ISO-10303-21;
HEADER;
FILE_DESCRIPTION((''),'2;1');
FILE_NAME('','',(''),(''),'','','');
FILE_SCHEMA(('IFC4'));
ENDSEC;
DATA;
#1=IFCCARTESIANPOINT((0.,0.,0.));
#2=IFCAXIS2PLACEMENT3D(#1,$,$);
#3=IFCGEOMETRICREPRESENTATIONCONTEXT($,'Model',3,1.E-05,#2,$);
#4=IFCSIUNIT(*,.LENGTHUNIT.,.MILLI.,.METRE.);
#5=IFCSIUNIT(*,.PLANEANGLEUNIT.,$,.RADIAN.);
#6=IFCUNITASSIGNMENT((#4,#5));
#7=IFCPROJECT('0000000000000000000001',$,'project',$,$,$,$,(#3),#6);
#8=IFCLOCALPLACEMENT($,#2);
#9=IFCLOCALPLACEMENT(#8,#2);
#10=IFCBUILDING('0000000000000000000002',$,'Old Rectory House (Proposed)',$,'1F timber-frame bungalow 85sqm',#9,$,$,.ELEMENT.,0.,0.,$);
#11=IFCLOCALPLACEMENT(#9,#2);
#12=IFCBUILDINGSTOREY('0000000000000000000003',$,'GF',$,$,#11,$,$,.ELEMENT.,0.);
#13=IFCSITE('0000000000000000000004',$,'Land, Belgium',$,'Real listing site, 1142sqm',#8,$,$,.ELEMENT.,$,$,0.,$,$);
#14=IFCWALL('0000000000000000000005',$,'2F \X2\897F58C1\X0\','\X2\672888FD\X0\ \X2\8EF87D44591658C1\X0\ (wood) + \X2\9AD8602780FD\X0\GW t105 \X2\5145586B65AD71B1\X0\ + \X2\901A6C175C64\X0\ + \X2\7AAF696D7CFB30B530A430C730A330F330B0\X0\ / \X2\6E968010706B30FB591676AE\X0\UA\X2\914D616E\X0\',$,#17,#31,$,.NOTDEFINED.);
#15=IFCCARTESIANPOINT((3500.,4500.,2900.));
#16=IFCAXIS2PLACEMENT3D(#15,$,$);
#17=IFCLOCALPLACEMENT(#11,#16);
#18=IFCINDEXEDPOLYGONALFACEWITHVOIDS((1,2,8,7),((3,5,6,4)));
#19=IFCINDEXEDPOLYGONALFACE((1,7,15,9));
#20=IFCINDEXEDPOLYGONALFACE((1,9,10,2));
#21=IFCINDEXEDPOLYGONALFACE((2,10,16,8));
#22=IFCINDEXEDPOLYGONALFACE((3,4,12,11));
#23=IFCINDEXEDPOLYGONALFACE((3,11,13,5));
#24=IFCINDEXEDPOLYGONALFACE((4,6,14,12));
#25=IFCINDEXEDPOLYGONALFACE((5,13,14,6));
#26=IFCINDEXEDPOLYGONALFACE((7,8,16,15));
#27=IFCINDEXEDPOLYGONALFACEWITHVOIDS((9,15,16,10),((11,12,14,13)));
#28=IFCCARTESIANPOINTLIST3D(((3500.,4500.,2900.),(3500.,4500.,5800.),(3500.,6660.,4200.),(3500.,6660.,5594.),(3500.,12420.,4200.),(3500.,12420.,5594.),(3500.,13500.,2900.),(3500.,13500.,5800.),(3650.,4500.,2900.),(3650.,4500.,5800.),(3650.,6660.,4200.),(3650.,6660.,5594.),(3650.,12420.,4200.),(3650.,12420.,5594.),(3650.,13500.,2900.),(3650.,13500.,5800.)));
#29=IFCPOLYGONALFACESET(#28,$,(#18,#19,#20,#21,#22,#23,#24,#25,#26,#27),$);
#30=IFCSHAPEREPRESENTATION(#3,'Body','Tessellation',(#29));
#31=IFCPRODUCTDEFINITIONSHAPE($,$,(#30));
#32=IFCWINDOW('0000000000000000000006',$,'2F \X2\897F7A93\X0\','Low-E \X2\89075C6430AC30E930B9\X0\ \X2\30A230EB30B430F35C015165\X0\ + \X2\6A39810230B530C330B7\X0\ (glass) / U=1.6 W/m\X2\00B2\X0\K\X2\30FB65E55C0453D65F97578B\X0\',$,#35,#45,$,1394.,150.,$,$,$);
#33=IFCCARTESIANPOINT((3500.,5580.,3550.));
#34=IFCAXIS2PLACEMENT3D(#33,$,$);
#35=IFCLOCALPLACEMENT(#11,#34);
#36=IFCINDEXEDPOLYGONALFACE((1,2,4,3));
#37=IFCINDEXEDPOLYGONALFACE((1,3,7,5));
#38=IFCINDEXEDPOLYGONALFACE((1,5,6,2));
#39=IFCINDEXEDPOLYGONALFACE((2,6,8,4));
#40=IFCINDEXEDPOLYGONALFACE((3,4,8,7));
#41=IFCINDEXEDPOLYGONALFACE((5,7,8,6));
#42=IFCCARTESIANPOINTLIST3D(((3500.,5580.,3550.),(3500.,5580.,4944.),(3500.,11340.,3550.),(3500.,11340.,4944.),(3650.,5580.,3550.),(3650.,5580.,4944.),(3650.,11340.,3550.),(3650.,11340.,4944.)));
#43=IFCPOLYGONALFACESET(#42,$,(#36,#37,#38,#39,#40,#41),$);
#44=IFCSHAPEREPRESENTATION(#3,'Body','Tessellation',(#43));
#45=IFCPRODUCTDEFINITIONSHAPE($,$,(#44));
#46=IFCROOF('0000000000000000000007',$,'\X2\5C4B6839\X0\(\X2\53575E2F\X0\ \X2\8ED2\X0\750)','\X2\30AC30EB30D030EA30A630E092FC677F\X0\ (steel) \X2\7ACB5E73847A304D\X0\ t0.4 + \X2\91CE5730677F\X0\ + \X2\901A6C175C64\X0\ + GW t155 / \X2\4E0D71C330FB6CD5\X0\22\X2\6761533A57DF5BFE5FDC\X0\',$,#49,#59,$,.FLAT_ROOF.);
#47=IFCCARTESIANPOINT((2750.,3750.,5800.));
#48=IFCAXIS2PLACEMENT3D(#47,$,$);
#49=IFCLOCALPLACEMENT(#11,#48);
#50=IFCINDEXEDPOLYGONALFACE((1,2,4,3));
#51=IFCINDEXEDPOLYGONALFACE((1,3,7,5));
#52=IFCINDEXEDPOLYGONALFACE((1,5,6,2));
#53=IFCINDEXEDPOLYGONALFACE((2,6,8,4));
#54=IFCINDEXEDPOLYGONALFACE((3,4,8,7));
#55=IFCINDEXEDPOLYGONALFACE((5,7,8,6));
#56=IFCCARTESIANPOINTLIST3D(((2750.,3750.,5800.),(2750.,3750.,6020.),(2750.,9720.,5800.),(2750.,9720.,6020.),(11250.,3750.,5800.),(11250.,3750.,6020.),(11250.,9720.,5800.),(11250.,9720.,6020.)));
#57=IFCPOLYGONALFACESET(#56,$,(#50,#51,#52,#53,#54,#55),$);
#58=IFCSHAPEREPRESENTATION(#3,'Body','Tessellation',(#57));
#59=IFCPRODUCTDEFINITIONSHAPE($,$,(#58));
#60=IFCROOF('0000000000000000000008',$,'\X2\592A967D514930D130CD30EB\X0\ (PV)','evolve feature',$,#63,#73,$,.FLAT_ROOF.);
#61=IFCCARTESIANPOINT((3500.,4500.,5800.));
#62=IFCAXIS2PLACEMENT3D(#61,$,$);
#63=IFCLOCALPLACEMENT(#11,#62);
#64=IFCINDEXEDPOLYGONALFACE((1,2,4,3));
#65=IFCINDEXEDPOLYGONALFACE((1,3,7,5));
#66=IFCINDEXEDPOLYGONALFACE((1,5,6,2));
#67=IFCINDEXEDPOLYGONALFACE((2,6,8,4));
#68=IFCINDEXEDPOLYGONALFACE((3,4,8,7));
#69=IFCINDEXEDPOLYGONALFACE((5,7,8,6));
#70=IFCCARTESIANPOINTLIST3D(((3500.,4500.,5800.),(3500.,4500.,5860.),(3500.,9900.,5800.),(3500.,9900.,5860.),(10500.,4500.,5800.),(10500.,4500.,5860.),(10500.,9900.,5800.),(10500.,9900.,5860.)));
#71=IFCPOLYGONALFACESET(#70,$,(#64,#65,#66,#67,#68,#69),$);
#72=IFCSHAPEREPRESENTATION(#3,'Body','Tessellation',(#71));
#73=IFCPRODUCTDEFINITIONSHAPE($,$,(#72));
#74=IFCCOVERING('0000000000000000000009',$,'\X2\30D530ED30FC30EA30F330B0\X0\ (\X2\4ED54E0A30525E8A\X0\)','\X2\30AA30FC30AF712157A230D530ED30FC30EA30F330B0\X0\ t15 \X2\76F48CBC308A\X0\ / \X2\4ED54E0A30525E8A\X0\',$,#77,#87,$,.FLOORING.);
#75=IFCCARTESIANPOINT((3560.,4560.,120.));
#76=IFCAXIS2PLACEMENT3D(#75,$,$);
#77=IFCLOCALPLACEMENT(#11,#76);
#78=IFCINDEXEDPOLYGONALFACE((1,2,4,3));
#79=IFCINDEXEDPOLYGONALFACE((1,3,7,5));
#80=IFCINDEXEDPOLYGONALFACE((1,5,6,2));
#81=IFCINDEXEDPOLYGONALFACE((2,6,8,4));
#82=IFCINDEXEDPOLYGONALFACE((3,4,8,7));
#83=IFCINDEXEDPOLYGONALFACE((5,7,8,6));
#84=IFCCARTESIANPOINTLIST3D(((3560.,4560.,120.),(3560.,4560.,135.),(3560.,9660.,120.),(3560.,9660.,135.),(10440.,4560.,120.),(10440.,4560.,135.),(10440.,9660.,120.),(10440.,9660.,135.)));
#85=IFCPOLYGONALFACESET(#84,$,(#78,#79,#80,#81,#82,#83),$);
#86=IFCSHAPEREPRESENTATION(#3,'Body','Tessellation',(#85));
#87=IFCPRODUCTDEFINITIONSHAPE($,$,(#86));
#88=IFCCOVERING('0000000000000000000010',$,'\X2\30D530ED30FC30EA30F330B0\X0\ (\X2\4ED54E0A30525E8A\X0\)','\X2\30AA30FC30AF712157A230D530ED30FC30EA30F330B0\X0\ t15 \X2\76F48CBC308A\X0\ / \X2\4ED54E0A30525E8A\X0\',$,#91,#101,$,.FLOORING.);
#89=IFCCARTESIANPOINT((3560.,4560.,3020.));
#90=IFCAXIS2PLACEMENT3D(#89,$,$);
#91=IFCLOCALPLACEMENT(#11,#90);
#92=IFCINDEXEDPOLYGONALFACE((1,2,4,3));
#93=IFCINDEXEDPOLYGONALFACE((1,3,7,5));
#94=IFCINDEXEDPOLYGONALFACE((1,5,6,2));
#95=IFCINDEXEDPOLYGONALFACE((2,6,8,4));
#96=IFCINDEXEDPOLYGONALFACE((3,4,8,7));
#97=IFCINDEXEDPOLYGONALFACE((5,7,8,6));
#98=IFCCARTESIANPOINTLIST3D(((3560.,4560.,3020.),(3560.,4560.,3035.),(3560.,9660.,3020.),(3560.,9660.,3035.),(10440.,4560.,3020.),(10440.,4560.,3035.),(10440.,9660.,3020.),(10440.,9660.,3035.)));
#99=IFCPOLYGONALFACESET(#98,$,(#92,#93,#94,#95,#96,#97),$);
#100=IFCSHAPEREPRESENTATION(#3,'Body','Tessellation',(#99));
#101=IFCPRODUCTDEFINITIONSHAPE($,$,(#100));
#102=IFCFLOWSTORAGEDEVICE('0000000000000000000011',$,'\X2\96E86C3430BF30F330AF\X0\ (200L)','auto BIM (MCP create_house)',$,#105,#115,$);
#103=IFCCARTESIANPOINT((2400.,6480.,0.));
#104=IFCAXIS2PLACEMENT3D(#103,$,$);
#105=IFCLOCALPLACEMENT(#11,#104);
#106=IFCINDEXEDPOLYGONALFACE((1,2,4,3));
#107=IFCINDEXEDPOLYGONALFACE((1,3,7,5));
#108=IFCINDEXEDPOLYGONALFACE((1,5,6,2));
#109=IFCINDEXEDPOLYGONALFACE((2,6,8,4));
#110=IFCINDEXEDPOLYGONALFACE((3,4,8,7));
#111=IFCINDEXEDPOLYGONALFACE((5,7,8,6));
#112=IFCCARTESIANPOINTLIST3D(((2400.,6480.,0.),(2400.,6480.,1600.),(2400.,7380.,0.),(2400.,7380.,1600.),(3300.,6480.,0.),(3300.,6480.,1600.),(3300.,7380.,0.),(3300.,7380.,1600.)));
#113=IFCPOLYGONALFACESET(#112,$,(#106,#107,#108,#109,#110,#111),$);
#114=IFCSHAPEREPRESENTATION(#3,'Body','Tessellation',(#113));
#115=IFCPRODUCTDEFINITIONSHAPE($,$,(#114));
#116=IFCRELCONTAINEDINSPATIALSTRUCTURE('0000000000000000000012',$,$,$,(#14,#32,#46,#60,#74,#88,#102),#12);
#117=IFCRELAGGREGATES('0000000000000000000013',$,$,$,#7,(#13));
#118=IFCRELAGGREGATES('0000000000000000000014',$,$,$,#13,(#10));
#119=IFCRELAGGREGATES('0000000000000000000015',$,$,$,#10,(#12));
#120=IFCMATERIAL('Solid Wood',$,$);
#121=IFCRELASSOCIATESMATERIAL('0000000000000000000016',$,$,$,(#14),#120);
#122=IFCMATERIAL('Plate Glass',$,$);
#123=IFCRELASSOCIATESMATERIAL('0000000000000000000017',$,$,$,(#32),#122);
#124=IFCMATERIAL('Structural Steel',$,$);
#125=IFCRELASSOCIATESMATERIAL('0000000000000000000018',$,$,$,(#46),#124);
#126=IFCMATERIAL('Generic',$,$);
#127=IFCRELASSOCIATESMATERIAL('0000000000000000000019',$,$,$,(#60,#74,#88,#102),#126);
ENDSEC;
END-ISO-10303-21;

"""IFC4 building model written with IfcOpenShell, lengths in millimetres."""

from ifc_helpers import new_model, si_unit, frame, frame_2d, origin, place, context, project, spatial, rectangle, extrude, material, element, fill, save


model = new_model("IFC4")

# Units and contexts
model_context = context("Model", 3, precision=1e-05, world=origin())
ifc_project = project(units=[si_unit("LENGTHUNIT", "METRE", prefix="MILLI"), si_unit("PLANEANGLEUNIT", "RADIAN")], contexts=[model_context])

# Site, building, storey
site_placement = place(None, origin())
site = spatial("IfcSite", under=ifc_project, at=site_placement, Name="Land, Belgium", ObjectType="Real listing site, 1142sqm", CompositionType="ELEMENT", RefElevation=0.0)
building_placement = place(site_placement, origin())
building = spatial("IfcBuilding", under=site, at=building_placement, Name="Old Rectory House (Proposed)", ObjectType="1F timber-frame bungalow 85sqm", CompositionType="ELEMENT", ElevationOfRefHeight=0.0, ElevationOfTerrain=0.0)
storey_placement = place(building_placement, origin())
storey = spatial("IfcBuildingStorey", under=building, at=storey_placement, Name="GF", CompositionType="ELEMENT", Elevation=0.0)

# Shared definitions
ifc_material_1 = material(Name="Solid Wood")
ifc_material_2 = material(Name="Generic")

# Shared definitions
ifc_material_3 = material(Name="Plate Glass")

# Wall, opening, window
wall_1_placement = place(storey_placement, frame((3500.0, 4500.0, 2900.0)))
wall_1 = element("IfcWall", 1, at=wall_1_placement, inside=storey, material=ifc_material_1, Name="2F 西壁", Description="木製 軸組外壁 (wood) + 高性能GW t105 充填断熱 + 通気層 + 窯業系サイディング / 準耐火・外皮UA配慮", PredefinedType="NOTDEFINED", context=model_context, shape_type="SweptSolid", body=[
    extrude(rectangle(XDim=150.0, YDim=9000.0, at=frame_2d((75.0, 4500.0))), frame((3500.0, 4500.0, 2900.0)), (0.0, 0.0, 1.0), 2900.0),
])
opening_1_placement = place(storey_placement, frame((3500.0, 5580.0, 3550.0)))
opening_1 = element("IfcOpeningElement", 2, at=opening_1_placement, cuts=wall_1, PredefinedType="NOTDEFINED", context=model_context, shape_type="SweptSolid", body=[
    extrude(rectangle(XDim=150.0, YDim=5760.0, at=frame_2d((75.0, 2880.0))), frame((3500.0, 5580.0, 3550.0)), (0.0, 0.0, 1.0), 1394.0),
])
window_1_placement = place(storey_placement, frame((3500.0, 5580.0, 3550.0)))
window_1 = element("IfcWindow", 3, at=window_1_placement, inside=storey, material=ifc_material_3, Name="2F 西窓", Description="Low-E 複層ガラス アルゴン封入 + 樹脂サッシ (glass) / U=1.6 W/m²K・日射取得型", OverallHeight=1394.0, OverallWidth=150.0, context=model_context, shape_type="SweptSolid", body=[
    extrude(rectangle(XDim=150.0, YDim=5760.0, at=frame_2d((75.0, 2880.0))), frame((3500.0, 5580.0, 3550.0)), (0.0, 0.0, 1.0), 1394.0),
])
fill(opening_1, window_1)

# Roofs
ifc_material_4 = material(Name="Structural Steel")
for number, where, name in (
    (4, (2750.0, 3750.0, 5800.0), "屋根(南帯 軒750)"),
):
    element("IfcRoof", number, at=place(storey_placement, frame(where)), inside=storey, material=ifc_material_4, Name=name, Description="ガルバリウム鋼板 (steel) 立平葺き t0.4 + 野地板 + 通気層 + GW t155 / 不燃・法22条区域対応", PredefinedType="FLAT_ROOF", context=model_context, shape_type="SweptSolid", body=[
        extrude(rectangle(XDim=8500.0, YDim=5970.0, at=frame_2d((4250.0, 2985.0))), frame((2750.0, 3750.0, 5800.0)), (0.0, 0.0, 1.0), 220.0),
    ])
roof_placement = place(storey_placement, frame((3500.0, 4500.0, 5800.0)))
element("IfcRoof", 5, at=roof_placement, inside=storey, material=ifc_material_2, Name="太陽光パネル (PV)", Description="evolve feature", PredefinedType="FLAT_ROOF", context=model_context, shape_type="SweptSolid", body=[
    extrude(rectangle(XDim=7000.0, YDim=5400.0, at=frame_2d((3500.0, 2700.0))), frame((3500.0, 4500.0, 5800.0)), (0.0, 0.0, 1.0), 60.0),
])

# Coverings
covering_1_placement = place(storey_placement, frame((3560.0, 4560.0, 120.0)))
element("IfcCovering", 6, at=covering_1_placement, inside=storey, material=ifc_material_2, Name="フローリング (仕上げ床)", Description="オーク無垢フローリング t15 直貼り / 仕上げ床", PredefinedType="FLOORING", context=model_context, shape_type="SweptSolid", body=[
    extrude(rectangle(XDim=6880.0, YDim=5100.0, at=frame_2d((3440.0, 2550.0))), frame((3560.0, 4560.0, 120.0)), (0.0, 0.0, 1.0), 15.0),
])
covering_2_placement = place(storey_placement, frame((3560.0, 4560.0, 3020.0)))
element("IfcCovering", 7, at=covering_2_placement, inside=storey, material=ifc_material_2, Name="フローリング (仕上げ床)", Description="オーク無垢フローリング t15 直貼り / 仕上げ床", PredefinedType="FLOORING", context=model_context, shape_type="SweptSolid", body=[
    extrude(rectangle(XDim=6880.0, YDim=5100.0, at=frame_2d((3440.0, 2550.0))), frame((3560.0, 4560.0, 3020.0)), (0.0, 0.0, 1.0), 15.0),
])

# Flow storage device
flow_storage_device_placement = place(storey_placement, frame((2400.0, 6480.0, 0.0)))
element("IfcFlowStorageDevice", 8, at=flow_storage_device_placement, inside=storey, material=ifc_material_2, Name="雨水タンク (200L)", Description="auto BIM (MCP create_house)", context=model_context, shape_type="SweptSolid", body=[
    extrude(rectangle(XDim=900.0, YDim=900.0, at=frame_2d((450.0, 450.0))), frame((2400.0, 6480.0, 0.0)), (0.0, 0.0, 1.0), 1600.0),
])

save(model, "model.ifc")
